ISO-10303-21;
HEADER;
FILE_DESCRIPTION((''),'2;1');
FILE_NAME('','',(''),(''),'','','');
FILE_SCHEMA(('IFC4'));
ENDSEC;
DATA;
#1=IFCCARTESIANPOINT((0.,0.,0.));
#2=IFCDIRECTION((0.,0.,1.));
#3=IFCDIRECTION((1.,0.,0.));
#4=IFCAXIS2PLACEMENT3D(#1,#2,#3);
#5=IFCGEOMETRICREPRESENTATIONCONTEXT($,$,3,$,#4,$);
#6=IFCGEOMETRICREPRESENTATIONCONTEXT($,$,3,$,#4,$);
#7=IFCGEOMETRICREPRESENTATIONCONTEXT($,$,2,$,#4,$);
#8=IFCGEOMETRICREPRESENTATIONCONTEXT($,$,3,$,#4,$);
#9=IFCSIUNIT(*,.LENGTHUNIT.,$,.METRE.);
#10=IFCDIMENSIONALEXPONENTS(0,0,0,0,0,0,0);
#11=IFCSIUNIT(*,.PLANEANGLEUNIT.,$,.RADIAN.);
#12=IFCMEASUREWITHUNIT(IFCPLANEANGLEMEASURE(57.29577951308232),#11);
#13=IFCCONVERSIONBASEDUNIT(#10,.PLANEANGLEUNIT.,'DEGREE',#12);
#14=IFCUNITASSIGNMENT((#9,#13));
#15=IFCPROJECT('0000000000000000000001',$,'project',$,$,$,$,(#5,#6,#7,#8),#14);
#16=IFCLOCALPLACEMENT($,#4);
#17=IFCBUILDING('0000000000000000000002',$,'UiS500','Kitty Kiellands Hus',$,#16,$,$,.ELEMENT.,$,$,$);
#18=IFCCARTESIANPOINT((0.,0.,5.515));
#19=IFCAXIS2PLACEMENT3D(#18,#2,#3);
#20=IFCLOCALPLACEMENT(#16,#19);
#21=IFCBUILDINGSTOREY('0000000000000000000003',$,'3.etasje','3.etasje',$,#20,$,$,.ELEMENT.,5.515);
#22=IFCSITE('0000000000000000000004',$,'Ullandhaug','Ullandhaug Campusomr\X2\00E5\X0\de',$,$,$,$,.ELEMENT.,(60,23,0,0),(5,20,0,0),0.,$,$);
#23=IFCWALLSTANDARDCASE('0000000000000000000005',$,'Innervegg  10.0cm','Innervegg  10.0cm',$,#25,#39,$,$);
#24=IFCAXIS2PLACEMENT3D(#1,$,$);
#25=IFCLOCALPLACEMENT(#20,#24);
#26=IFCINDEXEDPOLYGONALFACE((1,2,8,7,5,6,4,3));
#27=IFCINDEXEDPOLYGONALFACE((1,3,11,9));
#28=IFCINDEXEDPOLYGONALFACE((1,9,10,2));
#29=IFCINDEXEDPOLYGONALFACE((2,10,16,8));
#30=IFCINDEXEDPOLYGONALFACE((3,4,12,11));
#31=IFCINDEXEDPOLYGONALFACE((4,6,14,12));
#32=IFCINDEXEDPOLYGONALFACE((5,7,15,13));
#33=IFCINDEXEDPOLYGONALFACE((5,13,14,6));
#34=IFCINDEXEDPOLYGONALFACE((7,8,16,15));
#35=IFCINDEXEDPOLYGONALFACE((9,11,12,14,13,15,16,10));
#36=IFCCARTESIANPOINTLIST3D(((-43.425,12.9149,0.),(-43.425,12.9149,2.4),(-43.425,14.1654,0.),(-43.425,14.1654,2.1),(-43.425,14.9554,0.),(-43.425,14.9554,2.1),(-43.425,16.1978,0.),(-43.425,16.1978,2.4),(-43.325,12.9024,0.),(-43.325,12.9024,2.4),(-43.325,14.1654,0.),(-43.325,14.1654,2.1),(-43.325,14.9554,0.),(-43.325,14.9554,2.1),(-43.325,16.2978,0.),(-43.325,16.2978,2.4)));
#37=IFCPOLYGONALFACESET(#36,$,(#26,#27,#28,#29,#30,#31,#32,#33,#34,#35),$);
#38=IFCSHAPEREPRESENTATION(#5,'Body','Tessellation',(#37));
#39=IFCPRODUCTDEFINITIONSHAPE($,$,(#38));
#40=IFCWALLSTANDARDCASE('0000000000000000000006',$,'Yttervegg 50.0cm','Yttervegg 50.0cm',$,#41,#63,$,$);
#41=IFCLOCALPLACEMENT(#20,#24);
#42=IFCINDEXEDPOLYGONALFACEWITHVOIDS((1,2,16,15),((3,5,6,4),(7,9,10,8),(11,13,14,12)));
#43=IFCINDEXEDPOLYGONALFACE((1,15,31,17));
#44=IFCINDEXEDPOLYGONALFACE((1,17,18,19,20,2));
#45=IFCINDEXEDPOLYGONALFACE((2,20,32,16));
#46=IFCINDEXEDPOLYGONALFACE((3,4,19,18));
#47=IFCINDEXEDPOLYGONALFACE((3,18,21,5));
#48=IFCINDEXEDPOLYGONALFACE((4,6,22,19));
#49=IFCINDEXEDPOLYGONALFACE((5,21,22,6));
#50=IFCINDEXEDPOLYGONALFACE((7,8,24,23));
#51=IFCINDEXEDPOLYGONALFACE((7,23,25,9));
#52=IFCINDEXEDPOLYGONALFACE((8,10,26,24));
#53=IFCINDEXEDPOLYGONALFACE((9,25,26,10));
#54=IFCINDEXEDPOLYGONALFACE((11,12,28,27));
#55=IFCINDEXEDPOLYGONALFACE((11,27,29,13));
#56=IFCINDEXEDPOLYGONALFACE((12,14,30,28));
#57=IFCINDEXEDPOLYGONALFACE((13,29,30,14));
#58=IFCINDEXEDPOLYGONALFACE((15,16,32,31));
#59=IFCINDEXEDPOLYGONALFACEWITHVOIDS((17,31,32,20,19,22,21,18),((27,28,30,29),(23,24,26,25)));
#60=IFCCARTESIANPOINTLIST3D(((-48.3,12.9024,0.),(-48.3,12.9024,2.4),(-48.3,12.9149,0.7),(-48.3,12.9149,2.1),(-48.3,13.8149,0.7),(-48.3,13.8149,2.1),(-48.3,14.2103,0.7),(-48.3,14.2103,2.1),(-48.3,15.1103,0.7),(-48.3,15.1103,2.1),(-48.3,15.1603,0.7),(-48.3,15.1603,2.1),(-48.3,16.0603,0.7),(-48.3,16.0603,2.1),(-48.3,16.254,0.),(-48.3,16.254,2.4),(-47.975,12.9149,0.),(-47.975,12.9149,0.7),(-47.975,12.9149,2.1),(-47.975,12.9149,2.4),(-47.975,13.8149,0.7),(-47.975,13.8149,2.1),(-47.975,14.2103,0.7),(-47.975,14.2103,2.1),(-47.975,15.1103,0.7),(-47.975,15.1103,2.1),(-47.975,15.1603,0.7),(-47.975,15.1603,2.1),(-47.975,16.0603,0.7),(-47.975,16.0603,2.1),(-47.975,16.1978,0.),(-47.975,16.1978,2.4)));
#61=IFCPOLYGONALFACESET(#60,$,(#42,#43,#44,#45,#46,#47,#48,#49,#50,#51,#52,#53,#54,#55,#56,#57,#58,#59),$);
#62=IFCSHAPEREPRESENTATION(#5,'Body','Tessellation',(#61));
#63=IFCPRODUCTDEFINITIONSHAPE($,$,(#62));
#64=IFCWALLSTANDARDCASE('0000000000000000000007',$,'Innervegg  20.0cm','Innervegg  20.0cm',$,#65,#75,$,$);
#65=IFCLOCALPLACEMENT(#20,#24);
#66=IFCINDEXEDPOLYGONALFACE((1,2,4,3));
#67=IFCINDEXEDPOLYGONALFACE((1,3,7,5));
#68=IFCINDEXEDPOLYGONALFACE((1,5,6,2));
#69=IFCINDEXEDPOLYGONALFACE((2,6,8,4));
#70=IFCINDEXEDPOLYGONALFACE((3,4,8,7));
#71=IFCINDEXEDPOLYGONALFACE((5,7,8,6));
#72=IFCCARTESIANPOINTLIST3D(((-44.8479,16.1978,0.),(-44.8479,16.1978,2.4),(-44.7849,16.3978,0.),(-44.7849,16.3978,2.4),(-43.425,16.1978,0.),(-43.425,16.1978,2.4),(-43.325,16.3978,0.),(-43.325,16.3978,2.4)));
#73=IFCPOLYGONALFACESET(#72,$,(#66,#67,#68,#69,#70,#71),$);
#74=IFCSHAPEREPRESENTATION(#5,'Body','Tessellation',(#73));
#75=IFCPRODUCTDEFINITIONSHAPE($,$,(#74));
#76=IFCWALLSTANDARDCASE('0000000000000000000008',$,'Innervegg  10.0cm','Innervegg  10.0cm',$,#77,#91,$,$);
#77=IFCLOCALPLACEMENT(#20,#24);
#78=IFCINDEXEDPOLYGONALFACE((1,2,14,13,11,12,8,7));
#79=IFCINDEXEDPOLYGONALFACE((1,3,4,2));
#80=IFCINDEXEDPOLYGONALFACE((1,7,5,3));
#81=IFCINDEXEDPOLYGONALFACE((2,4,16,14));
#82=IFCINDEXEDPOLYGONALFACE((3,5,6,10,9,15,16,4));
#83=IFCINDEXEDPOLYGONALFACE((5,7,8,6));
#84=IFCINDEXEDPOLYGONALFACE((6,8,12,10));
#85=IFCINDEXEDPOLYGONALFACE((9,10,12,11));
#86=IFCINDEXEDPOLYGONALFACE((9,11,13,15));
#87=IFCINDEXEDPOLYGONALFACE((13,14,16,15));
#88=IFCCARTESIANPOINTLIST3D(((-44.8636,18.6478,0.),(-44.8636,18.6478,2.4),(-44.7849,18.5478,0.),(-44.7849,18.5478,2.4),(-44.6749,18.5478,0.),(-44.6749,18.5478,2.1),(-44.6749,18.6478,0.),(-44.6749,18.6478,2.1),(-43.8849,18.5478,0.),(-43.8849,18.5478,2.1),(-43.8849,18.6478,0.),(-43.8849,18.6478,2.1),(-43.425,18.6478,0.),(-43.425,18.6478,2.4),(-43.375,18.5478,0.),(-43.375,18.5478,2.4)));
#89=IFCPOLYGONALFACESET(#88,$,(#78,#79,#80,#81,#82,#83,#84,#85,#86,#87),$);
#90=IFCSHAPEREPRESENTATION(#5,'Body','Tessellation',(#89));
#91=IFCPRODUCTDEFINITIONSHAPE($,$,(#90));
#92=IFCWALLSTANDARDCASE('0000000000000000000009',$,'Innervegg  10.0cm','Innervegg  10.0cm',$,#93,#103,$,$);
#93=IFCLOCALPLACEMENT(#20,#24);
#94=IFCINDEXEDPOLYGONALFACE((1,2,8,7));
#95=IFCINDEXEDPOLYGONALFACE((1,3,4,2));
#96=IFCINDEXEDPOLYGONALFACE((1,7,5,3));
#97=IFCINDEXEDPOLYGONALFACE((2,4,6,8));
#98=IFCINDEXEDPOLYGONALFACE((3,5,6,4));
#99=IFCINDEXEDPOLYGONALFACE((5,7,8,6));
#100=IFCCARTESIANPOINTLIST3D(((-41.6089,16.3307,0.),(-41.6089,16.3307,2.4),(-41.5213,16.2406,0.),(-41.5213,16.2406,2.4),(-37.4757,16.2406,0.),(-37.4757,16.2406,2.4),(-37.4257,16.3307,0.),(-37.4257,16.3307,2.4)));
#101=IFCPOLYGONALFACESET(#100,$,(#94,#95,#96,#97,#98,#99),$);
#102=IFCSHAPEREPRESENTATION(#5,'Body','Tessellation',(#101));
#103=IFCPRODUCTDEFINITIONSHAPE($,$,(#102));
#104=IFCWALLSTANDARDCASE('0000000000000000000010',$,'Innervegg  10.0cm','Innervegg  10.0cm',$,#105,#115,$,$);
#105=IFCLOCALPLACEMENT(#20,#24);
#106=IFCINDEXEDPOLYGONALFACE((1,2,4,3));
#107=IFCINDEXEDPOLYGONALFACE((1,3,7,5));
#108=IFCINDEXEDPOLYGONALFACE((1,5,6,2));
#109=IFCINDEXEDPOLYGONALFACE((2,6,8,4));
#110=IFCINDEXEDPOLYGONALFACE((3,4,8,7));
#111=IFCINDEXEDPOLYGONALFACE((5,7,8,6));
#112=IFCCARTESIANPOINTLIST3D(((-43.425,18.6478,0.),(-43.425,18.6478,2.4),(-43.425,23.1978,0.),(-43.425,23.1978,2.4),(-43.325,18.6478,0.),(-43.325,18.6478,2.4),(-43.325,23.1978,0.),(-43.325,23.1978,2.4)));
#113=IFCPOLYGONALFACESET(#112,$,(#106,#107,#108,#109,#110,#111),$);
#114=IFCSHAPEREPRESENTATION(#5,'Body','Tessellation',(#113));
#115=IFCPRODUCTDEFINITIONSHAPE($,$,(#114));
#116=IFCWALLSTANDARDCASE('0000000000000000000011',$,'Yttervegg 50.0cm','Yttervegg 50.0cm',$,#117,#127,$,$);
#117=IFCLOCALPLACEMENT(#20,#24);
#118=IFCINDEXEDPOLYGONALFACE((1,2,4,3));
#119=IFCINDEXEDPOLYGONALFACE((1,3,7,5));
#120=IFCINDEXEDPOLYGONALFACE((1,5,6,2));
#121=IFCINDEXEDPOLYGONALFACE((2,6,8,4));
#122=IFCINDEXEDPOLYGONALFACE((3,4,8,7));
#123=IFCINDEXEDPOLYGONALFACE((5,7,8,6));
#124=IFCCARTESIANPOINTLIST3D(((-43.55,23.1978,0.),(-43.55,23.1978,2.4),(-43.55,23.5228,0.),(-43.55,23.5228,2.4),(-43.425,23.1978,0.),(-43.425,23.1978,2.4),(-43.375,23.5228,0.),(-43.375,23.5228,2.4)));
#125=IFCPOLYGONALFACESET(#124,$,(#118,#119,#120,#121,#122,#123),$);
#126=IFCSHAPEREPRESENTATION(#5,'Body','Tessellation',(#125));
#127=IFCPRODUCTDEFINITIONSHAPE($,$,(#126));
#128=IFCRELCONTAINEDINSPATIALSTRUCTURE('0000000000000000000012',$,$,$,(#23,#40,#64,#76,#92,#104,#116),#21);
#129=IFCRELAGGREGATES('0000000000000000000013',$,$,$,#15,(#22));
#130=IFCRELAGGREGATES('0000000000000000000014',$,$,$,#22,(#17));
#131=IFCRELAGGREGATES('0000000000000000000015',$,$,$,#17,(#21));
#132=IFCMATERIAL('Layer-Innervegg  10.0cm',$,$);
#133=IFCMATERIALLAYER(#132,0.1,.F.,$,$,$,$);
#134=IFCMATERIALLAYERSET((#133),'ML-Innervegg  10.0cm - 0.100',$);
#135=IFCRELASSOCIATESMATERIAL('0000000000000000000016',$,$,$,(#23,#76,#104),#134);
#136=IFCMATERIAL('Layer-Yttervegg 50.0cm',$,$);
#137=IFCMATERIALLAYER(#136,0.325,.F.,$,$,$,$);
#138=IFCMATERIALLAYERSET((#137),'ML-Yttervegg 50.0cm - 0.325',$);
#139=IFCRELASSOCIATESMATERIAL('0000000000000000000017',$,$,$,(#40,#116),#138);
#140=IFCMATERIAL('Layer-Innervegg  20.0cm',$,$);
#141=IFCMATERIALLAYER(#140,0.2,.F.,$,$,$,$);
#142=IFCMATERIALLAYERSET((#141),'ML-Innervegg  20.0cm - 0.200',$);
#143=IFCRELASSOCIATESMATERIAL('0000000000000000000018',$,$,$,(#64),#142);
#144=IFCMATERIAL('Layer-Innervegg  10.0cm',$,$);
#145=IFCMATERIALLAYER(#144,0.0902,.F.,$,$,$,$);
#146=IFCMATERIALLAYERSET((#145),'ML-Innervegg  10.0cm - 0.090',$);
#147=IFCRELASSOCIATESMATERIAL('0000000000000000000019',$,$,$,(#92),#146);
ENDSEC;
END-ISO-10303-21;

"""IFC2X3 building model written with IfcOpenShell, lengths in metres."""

from ifc_helpers import new_model, entity, si_unit, converted_unit, frame, origin_with_axes, place, context, project, spatial, polyline, outline, extrude, material, layer, layer_set, layer_usage, element, save


model = new_model("IFC2X3")

# Units and contexts
context_of_model_1 = context(None, 3, world=origin_with_axes())
context_of_model_2 = context(None, 3, world=origin_with_axes())
context_of_model_3 = context(None, 2, world=origin_with_axes())
context_of_model_4 = context(None, 3, world=origin_with_axes())
ifc_project = project(units=[si_unit("LENGTHUNIT", "METRE"), converted_unit("PLANEANGLEUNIT", "DEGREE", entity("IfcPlaneAngleMeasure", 57.29577951308232), si_unit("PLANEANGLEUNIT", "RADIAN"), dimensions=[0, 0, 0, 0, 0, 0, 0])], contexts=[context_of_model_1, context_of_model_2, context_of_model_3, context_of_model_4])

# Site, building, storey
site = spatial("IfcSite", under=ifc_project, Name="Ullandhaug", Description="Ullandhaug Campusområde", CompositionType="ELEMENT", RefLatitude=(60, 23, 0, 0), RefLongitude=(5, 20, 0, 0), RefElevation=0.0)
building_placement = place(None, origin_with_axes())
building = spatial("IfcBuilding", under=site, at=building_placement, Name="UiS500", Description="Kitty Kiellands Hus", CompositionType="ELEMENT")
storey_placement = place(building_placement, frame((0.0, 0.0, 5.515), z_axis=(0.0, 0.0, 1.0), x_axis=(1.0, 0.0, 0.0)))
storey = spatial("IfcBuildingStorey", under=building, at=storey_placement, Name="3.etasje", Description="3.etasje", CompositionType="ELEMENT", Elevation=5.515)

# Shared definitions
ifc_material_1 = material(Name="Layer-Yttervegg 50.0cm")
ifc_layer_1 = layer(ifc_material_1, 0.325, ventilated=False)
ifc_layer_set_1 = layer_set([ifc_layer_1], Name="ML-Yttervegg 50.0cm - 0.325")
ifc_layer_usage_1 = layer_usage(ifc_layer_set_1, "AXIS2", "POSITIVE", 0.0)

# Wall, opening
ifc_material_2 = material(Name="Layer-Innervegg  10.0cm")
ifc_layer_2 = layer(ifc_material_2, 0.1, ventilated=False)
ifc_layer_set_2 = layer_set([ifc_layer_2], Name="ML-Innervegg  10.0cm - 0.100")
ifc_layer_usage_2 = layer_usage(ifc_layer_set_2, "AXIS2", "POSITIVE", 0.0)
wall_1_placement = place(storey_placement, frame((-43.425, 16.1978, 0.0), z_axis=(0.0, 0.0, 1.0), x_axis=(0.0, -1.0, 0.0)))
wall_1 = element("IfcWallStandardCase", 1, at=wall_1_placement, inside=storey, material=ifc_layer_usage_2, Name="Innervegg  10.0cm", Description="Innervegg  10.0cm", context=context_of_model_1, shape_type="SweptSolid", body=[
    extrude(outline(polyline([(0.0, 0.0), (3.2828, 0.0), (3.2953, 0.1), (-0.1, 0.1), (0.0, 0.0)])), frame((0.0, 0.0, 0.0), z_axis=(0.0, 0.0, 1.0), x_axis=(1.0, 0.0, 0.0)), (0.0, 0.0, 1.0), 2.4),
])
opening_1_placement = place(wall_1_placement, frame((1.2424, 0.1, 0.0), z_axis=(0.0, 0.0, 1.0), x_axis=(1.0, 0.0, 0.0)))
element("IfcOpeningElement", 2, at=opening_1_placement, cuts=wall_1, context=context_of_model_1, shape_type="SweptSolid", body=[
    extrude(outline(polyline([(0.0, 0.0), (2.1, 0.0), (2.1, 0.79), (0.0, 0.79), (0.0, 0.0)])), frame((0.0, 0.0, 0.0), z_axis=(0.0, 1.0, 0.0), x_axis=(0.0, 0.0, 1.0)), (0.0, 0.0, -1.0), 0.1),
])

# Wall, openings
wall_2_placement = place(storey_placement, frame((-48.3, 16.254, 0.0), z_axis=(0.0, 0.0, 1.0), x_axis=(0.0, -1.0, 0.0)))
wall_2 = element("IfcWallStandardCase", 3, at=wall_2_placement, inside=storey, material=ifc_layer_usage_1, Name="Yttervegg 50.0cm", Description="Yttervegg 50.0cm", context=context_of_model_1, shape_type="SweptSolid", body=[
    extrude(outline(polyline([(0.0, 0.0), (3.3516, 0.0), (3.3391, 0.325), (0.0562, 0.325), (0.0, 0.0)])), frame((0.0, 0.0, 0.0), z_axis=(0.0, 0.0, 1.0), x_axis=(1.0, 0.0, 0.0)), (0.0, 0.0, 1.0), 2.4),
])
opening_2_placement = place(wall_2_placement, frame((2.4391, 0.325, 0.7), z_axis=(0.0, 0.0, 1.0), x_axis=(1.0, 0.0, 0.0)))
element("IfcOpeningElement", 4, at=opening_2_placement, cuts=wall_2, context=context_of_model_1, shape_type="SweptSolid", body=[
    extrude(outline(polyline([(0.0, 0.0), (1.4, 0.0), (1.4, 0.9), (0.0, 0.9), (0.0, 0.0)])), frame((0.0, 0.0, 0.0), z_axis=(0.0, 1.0, 0.0), x_axis=(0.0, 0.0, 1.0)), (0.0, 0.0, -1.0), 0.325),
])
opening_3_placement = place(wall_2_placement, frame((1.1437, 0.325, 0.7), z_axis=(0.0, 0.0, 1.0), x_axis=(1.0, 0.0, 0.0)))
element("IfcOpeningElement", 5, at=opening_3_placement, cuts=wall_2, context=context_of_model_1, shape_type="SweptSolid", body=[
    extrude(outline(polyline([(0.0, 0.0), (1.4, 0.0), (1.4, 0.9), (0.0, 0.9), (0.0, 0.0)])), frame((0.0, 0.0, 0.0), z_axis=(0.0, 1.0, 0.0), x_axis=(0.0, 0.0, 1.0)), (0.0, 0.0, -1.0), 0.325),
])
opening_4_placement = place(wall_2_placement, frame((0.1938, 0.325, 0.7), z_axis=(0.0, 0.0, 1.0), x_axis=(1.0, 0.0, 0.0)))
element("IfcOpeningElement", 6, at=opening_4_placement, cuts=wall_2, context=context_of_model_1, shape_type="SweptSolid", body=[
    extrude(outline(polyline([(0.0, 0.0), (1.4, 0.0), (1.4, 0.9), (0.0, 0.9), (0.0, 0.0)])), frame((0.0, 0.0, 0.0), z_axis=(0.0, 1.0, 0.0), x_axis=(0.0, 0.0, 1.0)), (0.0, 0.0, -1.0), 0.325),
])

# Wall
ifc_material_3 = material(Name="Layer-Innervegg  20.0cm")
ifc_layer_3 = layer(ifc_material_3, 0.2, ventilated=False)
ifc_layer_set_3 = layer_set([ifc_layer_3], Name="ML-Innervegg  20.0cm - 0.200")
ifc_layer_usage_3 = layer_usage(ifc_layer_set_3, "AXIS2", "POSITIVE", 0.0)
wall_3_placement = place(storey_placement, frame((-43.325, 16.3978, 0.0), z_axis=(0.0, 0.0, 1.0), x_axis=(-1.0, 0.0, 0.0)))
element("IfcWallStandardCase", 7, at=wall_3_placement, inside=storey, material=ifc_layer_usage_3, Name="Innervegg  20.0cm", Description="Innervegg  20.0cm", context=context_of_model_1, shape_type="SweptSolid", body=[
    extrude(outline(polyline([(0.0, 0.0), (1.4599, 0.0), (1.5229, 0.2), (0.1, 0.2), (0.0, 0.0)])), frame((0.0, 0.0, 0.0), z_axis=(0.0, 0.0, 1.0), x_axis=(1.0, 0.0, 0.0)), (0.0, 0.0, 1.0), 2.4),
])

# Wall, opening
wall_4_placement = place(storey_placement, frame((-43.425, 18.6478, 0.0), z_axis=(0.0, 0.0, 1.0), x_axis=(-1.0, 0.0, 0.0)))
wall_4 = element("IfcWallStandardCase", 8, at=wall_4_placement, inside=storey, material=ifc_layer_usage_2, Name="Innervegg  10.0cm", Description="Innervegg  10.0cm", context=context_of_model_1, shape_type="SweptSolid", body=[
    extrude(outline(polyline([(0.0, 0.0), (1.4386, 0.0), (1.3599, 0.1), (-0.05, 0.1), (0.0, 0.0)])), frame((0.0, 0.0, 0.0), z_axis=(0.0, 0.0, 1.0), x_axis=(1.0, 0.0, 0.0)), (0.0, 0.0, 1.0), 2.4),
])
opening_5_placement = place(wall_4_placement, frame((0.4599, 0.1, 0.0), z_axis=(0.0, 0.0, 1.0), x_axis=(1.0, 0.0, 0.0)))
element("IfcOpeningElement", 9, at=opening_5_placement, cuts=wall_4, context=context_of_model_1, shape_type="SweptSolid", body=[
    extrude(outline(polyline([(0.0, 0.0), (2.1, 0.0), (2.1, 0.79), (0.0, 0.79), (0.0, 0.0)])), frame((0.0, 0.0, 0.0), z_axis=(0.0, 1.0, 0.0), x_axis=(0.0, 0.0, 1.0)), (0.0, 0.0, -1.0), 0.1),
])

# Walls
ifc_material_4 = material(Name="Layer-Innervegg  10.0cm")
ifc_layer_4 = layer(ifc_material_4, 0.0902, ventilated=False)
ifc_layer_set_4 = layer_set([ifc_layer_4], Name="ML-Innervegg  10.0cm - 0.090")
ifc_layer_usage_4 = layer_usage(ifc_layer_set_4, "AXIS2", "POSITIVE", 0.0)
wall_5_placement = place(storey_placement, frame((-41.5213, 16.2406, 0.0), z_axis=(0.0, 0.0, 1.0), x_axis=(1.0, 0.0, 0.0)))
element("IfcWallStandardCase", 10, at=wall_5_placement, inside=storey, material=ifc_layer_usage_4, Name="Innervegg  10.0cm", Description="Innervegg  10.0cm", context=context_of_model_1, shape_type="SweptSolid", body=[
    extrude(outline(polyline([(0.0, 0.0), (4.0455, 0.0), (4.0955, 0.0902), (-0.0877, 0.0902), (0.0, 0.0)])), origin_with_axes(), (0.0, 0.0, 1.0), 2.4),
])
wall_6_placement = place(storey_placement, frame((-43.325, 18.6478, 0.0), z_axis=(0.0, 0.0, 1.0), x_axis=(0.0, 1.0, 0.0)))
element("IfcWallStandardCase", 11, at=wall_6_placement, inside=storey, material=ifc_layer_usage_2, Name="Innervegg  10.0cm", Description="Innervegg  10.0cm", context=context_of_model_1, shape_type="SweptSolid", body=[
    extrude(outline(polyline([(0.0, 0.0), (4.55, 0.0), (4.55, 0.1), (0.0, 0.1), (0.0, 0.0)])), frame((0.0, 0.0, 0.0), z_axis=(0.0, 0.0, 1.0), x_axis=(1.0, 0.0, 0.0)), (0.0, 0.0, 1.0), 2.4),
])
wall_7_placement = place(storey_placement, frame((-43.375, 23.5228, 0.0), z_axis=(0.0, 0.0, 1.0), x_axis=(-1.0, 0.0, 0.0)))
element("IfcWallStandardCase", 12, at=wall_7_placement, inside=storey, material=ifc_layer_usage_1, Name="Yttervegg 50.0cm", Description="Yttervegg 50.0cm", context=context_of_model_1, shape_type="SweptSolid", body=[
    extrude(outline(polyline([(0.0, 0.0), (0.175, 0.0), (0.175, 0.325), (0.05, 0.325), (0.0, 0.0)])), frame((0.0, 0.0, 0.0), z_axis=(0.0, 0.0, 1.0), x_axis=(1.0, 0.0, 0.0)), (0.0, 0.0, 1.0), 2.4),
])

save(model, "model.ifc")
